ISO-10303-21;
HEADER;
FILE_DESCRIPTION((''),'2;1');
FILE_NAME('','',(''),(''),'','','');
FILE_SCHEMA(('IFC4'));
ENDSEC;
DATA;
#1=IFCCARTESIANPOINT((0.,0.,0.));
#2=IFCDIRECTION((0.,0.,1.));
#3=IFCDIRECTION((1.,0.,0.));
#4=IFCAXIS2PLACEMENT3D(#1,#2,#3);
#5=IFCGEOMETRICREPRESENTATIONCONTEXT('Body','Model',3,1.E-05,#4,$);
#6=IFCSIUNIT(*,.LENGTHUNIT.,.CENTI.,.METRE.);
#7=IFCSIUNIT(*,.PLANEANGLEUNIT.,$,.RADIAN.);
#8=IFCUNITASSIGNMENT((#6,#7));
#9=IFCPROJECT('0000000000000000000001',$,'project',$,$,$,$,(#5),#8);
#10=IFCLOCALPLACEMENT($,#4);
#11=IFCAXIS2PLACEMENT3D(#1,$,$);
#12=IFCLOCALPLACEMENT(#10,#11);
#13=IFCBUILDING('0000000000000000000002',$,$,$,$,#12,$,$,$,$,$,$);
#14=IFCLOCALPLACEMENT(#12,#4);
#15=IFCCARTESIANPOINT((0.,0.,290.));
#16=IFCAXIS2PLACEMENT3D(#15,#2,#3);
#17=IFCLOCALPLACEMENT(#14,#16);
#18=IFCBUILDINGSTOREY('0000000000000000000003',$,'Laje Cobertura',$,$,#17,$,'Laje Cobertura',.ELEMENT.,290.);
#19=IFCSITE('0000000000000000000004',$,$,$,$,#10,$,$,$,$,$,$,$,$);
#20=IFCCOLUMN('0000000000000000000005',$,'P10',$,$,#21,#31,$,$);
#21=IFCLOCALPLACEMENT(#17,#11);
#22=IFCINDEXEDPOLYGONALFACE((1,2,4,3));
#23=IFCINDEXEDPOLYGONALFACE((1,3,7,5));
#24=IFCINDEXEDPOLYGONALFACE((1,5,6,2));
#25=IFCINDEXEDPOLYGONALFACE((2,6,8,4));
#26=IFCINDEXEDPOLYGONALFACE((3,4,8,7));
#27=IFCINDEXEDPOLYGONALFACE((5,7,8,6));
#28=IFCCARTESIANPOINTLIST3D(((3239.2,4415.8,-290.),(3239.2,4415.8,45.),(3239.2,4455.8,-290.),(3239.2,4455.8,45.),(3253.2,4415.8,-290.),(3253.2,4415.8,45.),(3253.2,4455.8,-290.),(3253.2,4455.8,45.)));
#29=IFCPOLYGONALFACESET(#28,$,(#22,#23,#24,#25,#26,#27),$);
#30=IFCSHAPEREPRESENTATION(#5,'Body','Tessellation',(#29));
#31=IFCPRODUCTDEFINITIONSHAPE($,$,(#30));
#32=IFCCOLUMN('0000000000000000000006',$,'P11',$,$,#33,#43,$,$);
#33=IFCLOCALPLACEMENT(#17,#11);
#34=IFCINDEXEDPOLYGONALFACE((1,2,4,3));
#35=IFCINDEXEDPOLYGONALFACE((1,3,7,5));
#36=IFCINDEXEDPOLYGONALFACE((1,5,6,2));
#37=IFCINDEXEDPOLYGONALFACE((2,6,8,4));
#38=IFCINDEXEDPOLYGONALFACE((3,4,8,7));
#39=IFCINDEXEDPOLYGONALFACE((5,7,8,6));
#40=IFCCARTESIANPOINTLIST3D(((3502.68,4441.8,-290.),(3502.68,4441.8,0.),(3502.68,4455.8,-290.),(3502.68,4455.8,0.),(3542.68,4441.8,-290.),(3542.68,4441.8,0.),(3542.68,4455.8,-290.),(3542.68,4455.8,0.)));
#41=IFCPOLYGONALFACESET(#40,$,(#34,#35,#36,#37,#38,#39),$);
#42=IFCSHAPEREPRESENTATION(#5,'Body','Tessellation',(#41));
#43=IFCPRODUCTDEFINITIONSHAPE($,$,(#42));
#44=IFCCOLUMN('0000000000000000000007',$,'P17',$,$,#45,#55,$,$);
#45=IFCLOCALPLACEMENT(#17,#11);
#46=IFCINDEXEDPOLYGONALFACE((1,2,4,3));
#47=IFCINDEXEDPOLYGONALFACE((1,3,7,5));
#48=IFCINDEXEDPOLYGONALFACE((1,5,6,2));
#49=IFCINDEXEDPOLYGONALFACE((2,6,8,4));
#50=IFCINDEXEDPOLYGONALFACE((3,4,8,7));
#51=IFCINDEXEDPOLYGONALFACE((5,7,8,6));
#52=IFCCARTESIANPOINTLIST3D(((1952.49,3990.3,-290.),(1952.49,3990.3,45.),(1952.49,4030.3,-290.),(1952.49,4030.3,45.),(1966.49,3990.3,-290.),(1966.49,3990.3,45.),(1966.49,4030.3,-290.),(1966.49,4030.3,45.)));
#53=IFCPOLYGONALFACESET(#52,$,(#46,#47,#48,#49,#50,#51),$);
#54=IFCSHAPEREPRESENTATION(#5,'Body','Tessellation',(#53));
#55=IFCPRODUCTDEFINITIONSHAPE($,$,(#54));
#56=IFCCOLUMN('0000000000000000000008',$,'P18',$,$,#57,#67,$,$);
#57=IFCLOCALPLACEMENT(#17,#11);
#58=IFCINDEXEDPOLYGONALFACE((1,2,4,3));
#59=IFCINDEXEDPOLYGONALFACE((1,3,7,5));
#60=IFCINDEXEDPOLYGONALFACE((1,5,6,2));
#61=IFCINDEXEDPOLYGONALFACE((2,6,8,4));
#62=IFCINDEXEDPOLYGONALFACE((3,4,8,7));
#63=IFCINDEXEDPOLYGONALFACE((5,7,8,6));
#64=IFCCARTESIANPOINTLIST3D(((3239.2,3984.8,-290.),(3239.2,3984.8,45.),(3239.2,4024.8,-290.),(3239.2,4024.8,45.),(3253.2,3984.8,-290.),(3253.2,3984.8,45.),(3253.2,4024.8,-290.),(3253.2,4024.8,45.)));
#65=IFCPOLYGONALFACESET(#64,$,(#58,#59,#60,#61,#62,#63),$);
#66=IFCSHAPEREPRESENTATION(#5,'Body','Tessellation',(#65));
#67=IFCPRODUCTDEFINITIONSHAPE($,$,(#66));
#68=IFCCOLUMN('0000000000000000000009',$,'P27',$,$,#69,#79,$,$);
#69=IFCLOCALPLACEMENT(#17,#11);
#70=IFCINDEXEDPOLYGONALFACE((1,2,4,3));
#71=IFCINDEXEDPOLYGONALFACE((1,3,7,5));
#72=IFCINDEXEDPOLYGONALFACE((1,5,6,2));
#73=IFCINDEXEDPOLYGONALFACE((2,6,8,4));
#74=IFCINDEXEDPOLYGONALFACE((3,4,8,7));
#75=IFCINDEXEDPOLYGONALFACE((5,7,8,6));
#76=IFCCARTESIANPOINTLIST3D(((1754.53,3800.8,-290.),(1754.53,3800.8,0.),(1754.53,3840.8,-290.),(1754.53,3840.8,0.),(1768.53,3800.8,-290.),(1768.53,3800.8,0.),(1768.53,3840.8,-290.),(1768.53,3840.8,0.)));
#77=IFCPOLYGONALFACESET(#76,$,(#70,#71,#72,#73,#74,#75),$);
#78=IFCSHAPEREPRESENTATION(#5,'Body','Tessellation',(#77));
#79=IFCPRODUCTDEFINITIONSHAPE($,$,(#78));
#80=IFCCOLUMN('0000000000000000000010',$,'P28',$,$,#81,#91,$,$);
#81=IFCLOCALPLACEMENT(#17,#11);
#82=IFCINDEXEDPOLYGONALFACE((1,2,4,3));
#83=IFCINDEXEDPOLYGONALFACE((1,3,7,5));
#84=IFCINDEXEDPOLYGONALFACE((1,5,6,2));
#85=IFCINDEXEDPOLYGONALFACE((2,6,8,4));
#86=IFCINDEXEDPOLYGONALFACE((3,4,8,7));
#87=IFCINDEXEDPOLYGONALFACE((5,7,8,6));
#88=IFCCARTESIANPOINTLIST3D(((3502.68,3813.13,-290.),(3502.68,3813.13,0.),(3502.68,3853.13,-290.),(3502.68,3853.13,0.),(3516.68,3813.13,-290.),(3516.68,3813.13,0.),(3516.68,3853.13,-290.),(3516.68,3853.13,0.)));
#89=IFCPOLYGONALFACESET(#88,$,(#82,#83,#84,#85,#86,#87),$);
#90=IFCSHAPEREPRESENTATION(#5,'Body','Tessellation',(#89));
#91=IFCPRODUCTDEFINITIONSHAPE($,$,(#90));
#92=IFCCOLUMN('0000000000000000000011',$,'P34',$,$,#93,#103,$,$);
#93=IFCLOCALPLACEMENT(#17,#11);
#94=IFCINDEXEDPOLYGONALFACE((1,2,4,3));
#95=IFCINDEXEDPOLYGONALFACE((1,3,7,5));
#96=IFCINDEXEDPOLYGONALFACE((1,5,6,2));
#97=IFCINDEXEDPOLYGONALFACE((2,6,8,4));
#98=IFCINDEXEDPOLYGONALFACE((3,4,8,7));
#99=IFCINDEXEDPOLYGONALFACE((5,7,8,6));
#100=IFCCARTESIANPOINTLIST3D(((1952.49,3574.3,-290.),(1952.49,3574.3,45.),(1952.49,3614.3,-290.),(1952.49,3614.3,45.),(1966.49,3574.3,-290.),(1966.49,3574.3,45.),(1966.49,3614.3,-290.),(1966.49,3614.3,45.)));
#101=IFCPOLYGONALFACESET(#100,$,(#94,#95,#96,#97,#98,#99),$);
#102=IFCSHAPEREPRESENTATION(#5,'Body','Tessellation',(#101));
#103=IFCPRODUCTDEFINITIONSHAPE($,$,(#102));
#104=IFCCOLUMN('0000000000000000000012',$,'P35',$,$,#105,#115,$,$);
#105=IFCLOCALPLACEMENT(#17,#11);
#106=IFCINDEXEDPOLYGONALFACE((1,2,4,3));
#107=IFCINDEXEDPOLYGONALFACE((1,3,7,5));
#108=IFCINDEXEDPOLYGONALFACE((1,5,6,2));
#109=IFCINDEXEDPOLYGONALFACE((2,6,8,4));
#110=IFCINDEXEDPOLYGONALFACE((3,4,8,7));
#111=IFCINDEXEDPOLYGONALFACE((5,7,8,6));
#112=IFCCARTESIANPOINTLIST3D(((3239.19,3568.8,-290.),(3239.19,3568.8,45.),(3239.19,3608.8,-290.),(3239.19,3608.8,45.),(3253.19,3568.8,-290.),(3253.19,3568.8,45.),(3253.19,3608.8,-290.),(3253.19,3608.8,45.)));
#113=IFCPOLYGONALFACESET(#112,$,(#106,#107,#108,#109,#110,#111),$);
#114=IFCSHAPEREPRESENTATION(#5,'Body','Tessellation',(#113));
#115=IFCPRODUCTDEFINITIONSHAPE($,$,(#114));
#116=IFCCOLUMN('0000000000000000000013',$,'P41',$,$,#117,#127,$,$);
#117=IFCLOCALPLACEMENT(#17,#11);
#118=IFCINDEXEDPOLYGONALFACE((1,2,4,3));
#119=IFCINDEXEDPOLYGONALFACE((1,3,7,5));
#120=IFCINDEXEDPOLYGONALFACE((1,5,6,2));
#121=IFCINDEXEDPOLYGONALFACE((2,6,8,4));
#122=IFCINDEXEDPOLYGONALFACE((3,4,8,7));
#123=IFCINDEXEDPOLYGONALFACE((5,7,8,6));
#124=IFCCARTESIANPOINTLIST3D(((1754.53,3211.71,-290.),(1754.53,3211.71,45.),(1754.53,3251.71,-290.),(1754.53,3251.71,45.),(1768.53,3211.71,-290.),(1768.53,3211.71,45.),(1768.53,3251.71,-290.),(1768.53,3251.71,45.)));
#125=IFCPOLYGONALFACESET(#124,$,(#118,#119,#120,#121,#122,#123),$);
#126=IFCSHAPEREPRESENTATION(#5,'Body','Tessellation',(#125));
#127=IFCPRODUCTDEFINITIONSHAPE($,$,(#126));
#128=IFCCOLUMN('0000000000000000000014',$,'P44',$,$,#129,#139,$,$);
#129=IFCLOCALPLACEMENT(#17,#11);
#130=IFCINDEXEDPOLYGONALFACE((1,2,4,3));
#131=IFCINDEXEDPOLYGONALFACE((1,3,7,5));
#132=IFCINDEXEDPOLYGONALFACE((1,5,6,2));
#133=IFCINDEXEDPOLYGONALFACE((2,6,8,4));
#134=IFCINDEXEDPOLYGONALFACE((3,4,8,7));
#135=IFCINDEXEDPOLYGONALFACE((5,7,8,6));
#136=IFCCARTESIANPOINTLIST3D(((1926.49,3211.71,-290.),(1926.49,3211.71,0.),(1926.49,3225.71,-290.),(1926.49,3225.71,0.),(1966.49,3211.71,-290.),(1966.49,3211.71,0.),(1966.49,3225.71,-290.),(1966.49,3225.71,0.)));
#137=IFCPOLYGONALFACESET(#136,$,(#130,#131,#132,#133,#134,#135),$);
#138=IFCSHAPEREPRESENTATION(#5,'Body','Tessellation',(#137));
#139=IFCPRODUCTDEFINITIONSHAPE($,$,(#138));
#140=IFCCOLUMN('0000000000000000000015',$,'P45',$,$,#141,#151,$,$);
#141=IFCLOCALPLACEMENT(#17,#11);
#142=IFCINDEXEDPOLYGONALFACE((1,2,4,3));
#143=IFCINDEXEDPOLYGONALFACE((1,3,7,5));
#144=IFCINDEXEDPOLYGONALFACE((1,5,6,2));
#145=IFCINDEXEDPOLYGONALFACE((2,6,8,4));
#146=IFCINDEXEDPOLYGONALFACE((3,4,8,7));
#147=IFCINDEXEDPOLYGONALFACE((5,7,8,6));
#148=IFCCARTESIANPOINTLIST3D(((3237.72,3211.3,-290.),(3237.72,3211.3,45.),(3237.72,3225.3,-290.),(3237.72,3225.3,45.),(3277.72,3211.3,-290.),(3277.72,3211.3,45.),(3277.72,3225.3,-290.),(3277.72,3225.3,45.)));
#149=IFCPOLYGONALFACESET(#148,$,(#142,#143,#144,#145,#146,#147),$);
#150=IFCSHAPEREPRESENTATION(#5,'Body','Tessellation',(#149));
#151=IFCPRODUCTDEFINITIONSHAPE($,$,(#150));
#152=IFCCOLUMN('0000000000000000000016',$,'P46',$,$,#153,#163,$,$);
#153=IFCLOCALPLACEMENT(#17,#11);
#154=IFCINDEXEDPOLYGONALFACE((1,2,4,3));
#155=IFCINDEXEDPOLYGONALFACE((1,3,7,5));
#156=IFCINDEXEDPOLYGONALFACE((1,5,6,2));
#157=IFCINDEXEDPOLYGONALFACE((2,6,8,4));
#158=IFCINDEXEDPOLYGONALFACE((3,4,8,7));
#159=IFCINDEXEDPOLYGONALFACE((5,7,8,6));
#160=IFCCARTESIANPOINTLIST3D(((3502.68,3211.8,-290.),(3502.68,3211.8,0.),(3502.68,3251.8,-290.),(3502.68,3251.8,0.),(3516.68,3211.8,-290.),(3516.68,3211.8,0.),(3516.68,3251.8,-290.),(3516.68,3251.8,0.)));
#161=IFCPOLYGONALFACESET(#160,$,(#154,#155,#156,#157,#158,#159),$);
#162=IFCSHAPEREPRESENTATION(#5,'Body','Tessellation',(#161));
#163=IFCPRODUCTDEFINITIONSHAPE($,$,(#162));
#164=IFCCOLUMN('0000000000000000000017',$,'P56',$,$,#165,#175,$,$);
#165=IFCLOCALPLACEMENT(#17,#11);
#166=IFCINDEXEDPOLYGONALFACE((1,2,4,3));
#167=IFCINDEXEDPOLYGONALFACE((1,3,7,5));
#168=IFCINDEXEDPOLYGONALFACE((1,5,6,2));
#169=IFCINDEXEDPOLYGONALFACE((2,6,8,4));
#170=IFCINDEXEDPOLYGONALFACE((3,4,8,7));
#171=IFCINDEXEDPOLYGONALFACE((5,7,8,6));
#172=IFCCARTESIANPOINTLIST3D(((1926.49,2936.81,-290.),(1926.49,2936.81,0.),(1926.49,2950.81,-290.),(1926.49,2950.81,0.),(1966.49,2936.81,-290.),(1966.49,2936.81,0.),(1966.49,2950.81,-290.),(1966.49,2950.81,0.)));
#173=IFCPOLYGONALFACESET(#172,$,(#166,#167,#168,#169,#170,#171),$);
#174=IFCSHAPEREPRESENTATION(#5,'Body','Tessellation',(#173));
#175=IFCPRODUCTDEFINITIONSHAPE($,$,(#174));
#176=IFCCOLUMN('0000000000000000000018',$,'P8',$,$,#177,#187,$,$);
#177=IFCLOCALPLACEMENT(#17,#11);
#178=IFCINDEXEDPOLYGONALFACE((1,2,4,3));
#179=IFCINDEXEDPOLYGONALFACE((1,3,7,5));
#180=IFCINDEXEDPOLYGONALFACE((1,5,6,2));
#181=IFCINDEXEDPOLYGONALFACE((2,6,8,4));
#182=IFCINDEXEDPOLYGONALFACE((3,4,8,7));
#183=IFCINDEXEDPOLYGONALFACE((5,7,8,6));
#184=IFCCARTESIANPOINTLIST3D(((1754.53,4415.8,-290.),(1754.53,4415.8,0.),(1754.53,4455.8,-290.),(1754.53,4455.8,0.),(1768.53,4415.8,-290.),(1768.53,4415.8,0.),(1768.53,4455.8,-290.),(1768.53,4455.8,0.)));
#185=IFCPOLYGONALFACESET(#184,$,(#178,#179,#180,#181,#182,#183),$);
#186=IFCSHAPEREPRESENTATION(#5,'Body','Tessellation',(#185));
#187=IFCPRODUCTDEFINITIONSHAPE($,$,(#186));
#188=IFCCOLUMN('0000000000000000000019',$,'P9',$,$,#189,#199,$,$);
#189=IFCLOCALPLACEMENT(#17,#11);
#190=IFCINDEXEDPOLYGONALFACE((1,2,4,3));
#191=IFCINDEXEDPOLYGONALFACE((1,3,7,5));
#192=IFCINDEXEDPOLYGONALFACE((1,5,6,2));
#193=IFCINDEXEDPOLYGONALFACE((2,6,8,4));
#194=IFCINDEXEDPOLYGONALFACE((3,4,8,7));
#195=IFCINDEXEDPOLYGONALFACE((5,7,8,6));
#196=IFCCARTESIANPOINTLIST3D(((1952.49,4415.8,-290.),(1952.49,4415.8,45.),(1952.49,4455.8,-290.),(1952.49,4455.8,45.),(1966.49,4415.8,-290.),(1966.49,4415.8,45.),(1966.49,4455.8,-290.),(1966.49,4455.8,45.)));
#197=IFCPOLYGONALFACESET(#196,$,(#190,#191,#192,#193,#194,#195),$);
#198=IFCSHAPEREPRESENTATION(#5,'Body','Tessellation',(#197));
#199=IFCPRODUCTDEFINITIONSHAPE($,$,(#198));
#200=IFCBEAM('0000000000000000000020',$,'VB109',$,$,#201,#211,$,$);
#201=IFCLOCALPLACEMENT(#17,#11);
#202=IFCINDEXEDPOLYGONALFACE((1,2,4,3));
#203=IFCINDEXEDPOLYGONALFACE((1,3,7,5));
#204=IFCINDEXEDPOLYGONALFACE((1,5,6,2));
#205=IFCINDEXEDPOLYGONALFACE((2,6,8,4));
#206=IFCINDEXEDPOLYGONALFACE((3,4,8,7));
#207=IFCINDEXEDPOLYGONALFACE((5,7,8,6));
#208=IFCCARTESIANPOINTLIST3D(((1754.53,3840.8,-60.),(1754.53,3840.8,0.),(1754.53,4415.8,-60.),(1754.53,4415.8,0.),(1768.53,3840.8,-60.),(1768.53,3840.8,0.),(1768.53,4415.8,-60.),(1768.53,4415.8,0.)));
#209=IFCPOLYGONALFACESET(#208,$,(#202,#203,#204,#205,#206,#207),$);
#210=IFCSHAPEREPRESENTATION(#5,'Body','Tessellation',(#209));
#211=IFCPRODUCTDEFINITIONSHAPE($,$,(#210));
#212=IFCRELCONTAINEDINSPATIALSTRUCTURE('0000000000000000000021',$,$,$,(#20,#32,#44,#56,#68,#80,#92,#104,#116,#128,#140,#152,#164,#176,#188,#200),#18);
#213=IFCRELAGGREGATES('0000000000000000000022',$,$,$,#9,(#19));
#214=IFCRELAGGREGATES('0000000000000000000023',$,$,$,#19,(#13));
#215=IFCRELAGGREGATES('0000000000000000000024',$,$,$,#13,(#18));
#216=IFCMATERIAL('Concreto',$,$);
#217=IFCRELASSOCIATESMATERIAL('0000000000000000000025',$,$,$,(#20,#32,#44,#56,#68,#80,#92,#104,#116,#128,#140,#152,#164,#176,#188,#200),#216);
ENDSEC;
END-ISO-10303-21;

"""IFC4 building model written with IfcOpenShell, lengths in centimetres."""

from ifc_helpers import new_model, si_unit, frame, origin, origin_with_axes, origin_2d_with_axis, place, context, project, spatial, rectangle, extrude, material, element, save


model = new_model("IFC4")

# Units and contexts
model_context = context("Model", 3, precision=1e-05, world=origin_with_axes(), identifier="Body")
ifc_project = project(units=[si_unit("LENGTHUNIT", "METRE", prefix="CENTI"), si_unit("PLANEANGLEUNIT", "RADIAN")], contexts=[model_context])

# Site, building, storey
site_placement = place(None, origin_with_axes())
site = spatial("IfcSite", under=ifc_project, at=site_placement)
building_placement = place(site_placement, origin())
building = spatial("IfcBuilding", under=site, at=building_placement)
placement = place(building_placement, origin_with_axes())
storey_placement = place(placement, frame((0.0, 0.0, 290.0), z_axis=(0.0, 0.0, 1.0), x_axis=(1.0, 0.0, 0.0)))
storey = spatial("IfcBuildingStorey", under=building, at=storey_placement, Name="Laje Cobertura", LongName="Laje Cobertura", CompositionType="ELEMENT", Elevation=290.0)

# Columns
ifc_material = material(Name="Concreto")
column_1_placement = place(storey_placement, frame((3246.2, 4435.8, 45.0), z_axis=(0.0, 0.0, 1.0), x_axis=(1.0, 0.0, 0.0)))
element("IfcColumn", 1, at=column_1_placement, inside=storey, material=ifc_material, Name="P10", context=model_context, shape_type="SolidModel", body=[
    extrude(rectangle(XDim=14.0, YDim=40.0, at=origin_2d_with_axis()), origin_with_axes(), (0.0, 0.0, -1.0), 335.0),
])
column_2_placement = place(storey_placement, frame((3522.68, 4448.8, 0.0), z_axis=(0.0, 0.0, 1.0), x_axis=(1.0, 0.0, 0.0)))
element("IfcColumn", 2, at=column_2_placement, inside=storey, material=ifc_material, Name="P11", context=model_context, shape_type="SolidModel", body=[
    extrude(rectangle(XDim=14.0, YDim=40.0, at=origin_2d_with_axis()), frame((0.0, 0.0, 0.0), z_axis=(0.0, 0.0, 1.0), x_axis=(0.0, -1.0, 0.0)), (0.0, 0.0, -1.0), 290.0),
])
for number, where, z_axis, x_axis, name in (
    (3, (1959.49, 4010.3, 45.0), (0.0, 0.0, 1.0), (1.0, 0.0, 0.0), "P17"),
    (4, (3246.2, 4004.8, 45.0), (0.0, 0.0, 1.0), (1.0, 0.0, 0.0), "P18"),
):
    element("IfcColumn", number, at=place(storey_placement, frame(where, z_axis=z_axis, x_axis=x_axis)), inside=storey, material=ifc_material, Name=name, context=model_context, shape_type="SolidModel", body=[
        extrude(rectangle(XDim=14.0, YDim=40.0, at=origin_2d_with_axis()), origin_with_axes(), (0.0, 0.0, -1.0), 335.0),
    ])
for number, where, z_axis, x_axis, name in (
    (5, (1761.53, 3820.8, 0.0), (0.0, 0.0, 1.0), (1.0, 0.0, 0.0), "P27"),
    (6, (3509.68, 3833.13, 0.0), (0.0, 0.0, 1.0), (1.0, 0.0, 0.0), "P28"),
):
    element("IfcColumn", number, at=place(storey_placement, frame(where, z_axis=z_axis, x_axis=x_axis)), inside=storey, material=ifc_material, Name=name, context=model_context, shape_type="SolidModel", body=[
        extrude(rectangle(XDim=14.0, YDim=40.0, at=origin_2d_with_axis()), origin_with_axes(), (0.0, 0.0, -1.0), 290.0),
    ])
for number, where, z_axis, x_axis, name in (
    (7, (1959.49, 3594.3, 45.0), (0.0, 0.0, 1.0), (1.0, 0.0, 0.0), "P34"),
    (8, (3246.19, 3588.8, 45.0), (0.0, 0.0, 1.0), (1.0, 0.0, 0.0), "P35"),
    (9, (1761.53, 3231.71, 45.0), (0.0, 0.0, 1.0), (1.0, 0.0, 0.0), "P41"),
):
    element("IfcColumn", number, at=place(storey_placement, frame(where, z_axis=z_axis, x_axis=x_axis)), inside=storey, material=ifc_material, Name=name, context=model_context, shape_type="SolidModel", body=[
        extrude(rectangle(XDim=14.0, YDim=40.0, at=origin_2d_with_axis()), origin_with_axes(), (0.0, 0.0, -1.0), 335.0),
    ])
column_3_placement = place(storey_placement, frame((1946.49, 3218.71, 0.0), z_axis=(0.0, 0.0, 1.0), x_axis=(1.0, 0.0, 0.0)))
element("IfcColumn", 10, at=column_3_placement, inside=storey, material=ifc_material, Name="P44", context=model_context, shape_type="SolidModel", body=[
    extrude(rectangle(XDim=14.0, YDim=40.0, at=origin_2d_with_axis()), frame((0.0, 0.0, 0.0), z_axis=(0.0, 0.0, 1.0), x_axis=(0.0, -1.0, 0.0)), (0.0, 0.0, -1.0), 290.0),
])
column_4_placement = place(storey_placement, frame((3257.72, 3218.3, 45.0), z_axis=(0.0, 0.0, 1.0), x_axis=(1.0, 0.0, 0.0)))
element("IfcColumn", 11, at=column_4_placement, inside=storey, material=ifc_material, Name="P45", context=model_context, shape_type="SolidModel", body=[
    extrude(rectangle(XDim=14.0, YDim=40.0, at=origin_2d_with_axis()), frame((0.0, 0.0, 0.0), z_axis=(0.0, 0.0, 1.0), x_axis=(0.0, -1.0, 0.0)), (0.0, 0.0, -1.0), 335.0),
])
column_5_placement = place(storey_placement, frame((3509.68, 3231.8, 0.0), z_axis=(0.0, 0.0, 1.0), x_axis=(1.0, 0.0, 0.0)))
element("IfcColumn", 12, at=column_5_placement, inside=storey, material=ifc_material, Name="P46", context=model_context, shape_type="SolidModel", body=[
    extrude(rectangle(XDim=14.0, YDim=40.0, at=origin_2d_with_axis()), origin_with_axes(), (0.0, 0.0, -1.0), 290.0),
])
column_6_placement = place(storey_placement, frame((1946.49, 2943.81, 0.0), z_axis=(0.0, 0.0, 1.0), x_axis=(1.0, 0.0, 0.0)))
element("IfcColumn", 13, at=column_6_placement, inside=storey, material=ifc_material, Name="P56", context=model_context, shape_type="SolidModel", body=[
    extrude(rectangle(XDim=14.0, YDim=40.0, at=origin_2d_with_axis()), frame((0.0, 0.0, 0.0), z_axis=(0.0, 0.0, 1.0), x_axis=(0.0, -1.0, 0.0)), (0.0, 0.0, -1.0), 290.0),
])
column_7_placement = place(storey_placement, frame((1761.53, 4435.8, 0.0), z_axis=(0.0, 0.0, 1.0), x_axis=(1.0, 0.0, 0.0)))
element("IfcColumn", 14, at=column_7_placement, inside=storey, material=ifc_material, Name="P8", context=model_context, shape_type="SolidModel", body=[
    extrude(rectangle(XDim=14.0, YDim=40.0, at=origin_2d_with_axis()), origin_with_axes(), (0.0, 0.0, -1.0), 290.0),
])
column_8_placement = place(storey_placement, frame((1959.49, 4435.8, 45.0), z_axis=(0.0, 0.0, 1.0), x_axis=(1.0, 0.0, 0.0)))
element("IfcColumn", 15, at=column_8_placement, inside=storey, material=ifc_material, Name="P9", context=model_context, shape_type="SolidModel", body=[
    extrude(rectangle(XDim=14.0, YDim=40.0, at=origin_2d_with_axis()), origin_with_axes(), (0.0, 0.0, -1.0), 335.0),
])

# Beam
beam_1_placement = place(storey_placement, frame((1761.53, 4128.3, 0.0), z_axis=(0.0, 0.0, 1.0), x_axis=(1.0, 0.0, 0.0)))
element("IfcBeam", 16, at=beam_1_placement, inside=storey, material=ifc_material, Name="VB109", context=model_context, shape_type="SolidModel", body=[
    extrude(rectangle(XDim=14.0, YDim=60.0, at=origin_2d_with_axis()), frame((0.0, -287.5, -30.0), z_axis=(0.0, 1.0, 0.0), x_axis=(-1.0, 0.0, 0.0)), (0.0, 0.0, 1.0), 575.0),
])

save(model, "model.ifc")
